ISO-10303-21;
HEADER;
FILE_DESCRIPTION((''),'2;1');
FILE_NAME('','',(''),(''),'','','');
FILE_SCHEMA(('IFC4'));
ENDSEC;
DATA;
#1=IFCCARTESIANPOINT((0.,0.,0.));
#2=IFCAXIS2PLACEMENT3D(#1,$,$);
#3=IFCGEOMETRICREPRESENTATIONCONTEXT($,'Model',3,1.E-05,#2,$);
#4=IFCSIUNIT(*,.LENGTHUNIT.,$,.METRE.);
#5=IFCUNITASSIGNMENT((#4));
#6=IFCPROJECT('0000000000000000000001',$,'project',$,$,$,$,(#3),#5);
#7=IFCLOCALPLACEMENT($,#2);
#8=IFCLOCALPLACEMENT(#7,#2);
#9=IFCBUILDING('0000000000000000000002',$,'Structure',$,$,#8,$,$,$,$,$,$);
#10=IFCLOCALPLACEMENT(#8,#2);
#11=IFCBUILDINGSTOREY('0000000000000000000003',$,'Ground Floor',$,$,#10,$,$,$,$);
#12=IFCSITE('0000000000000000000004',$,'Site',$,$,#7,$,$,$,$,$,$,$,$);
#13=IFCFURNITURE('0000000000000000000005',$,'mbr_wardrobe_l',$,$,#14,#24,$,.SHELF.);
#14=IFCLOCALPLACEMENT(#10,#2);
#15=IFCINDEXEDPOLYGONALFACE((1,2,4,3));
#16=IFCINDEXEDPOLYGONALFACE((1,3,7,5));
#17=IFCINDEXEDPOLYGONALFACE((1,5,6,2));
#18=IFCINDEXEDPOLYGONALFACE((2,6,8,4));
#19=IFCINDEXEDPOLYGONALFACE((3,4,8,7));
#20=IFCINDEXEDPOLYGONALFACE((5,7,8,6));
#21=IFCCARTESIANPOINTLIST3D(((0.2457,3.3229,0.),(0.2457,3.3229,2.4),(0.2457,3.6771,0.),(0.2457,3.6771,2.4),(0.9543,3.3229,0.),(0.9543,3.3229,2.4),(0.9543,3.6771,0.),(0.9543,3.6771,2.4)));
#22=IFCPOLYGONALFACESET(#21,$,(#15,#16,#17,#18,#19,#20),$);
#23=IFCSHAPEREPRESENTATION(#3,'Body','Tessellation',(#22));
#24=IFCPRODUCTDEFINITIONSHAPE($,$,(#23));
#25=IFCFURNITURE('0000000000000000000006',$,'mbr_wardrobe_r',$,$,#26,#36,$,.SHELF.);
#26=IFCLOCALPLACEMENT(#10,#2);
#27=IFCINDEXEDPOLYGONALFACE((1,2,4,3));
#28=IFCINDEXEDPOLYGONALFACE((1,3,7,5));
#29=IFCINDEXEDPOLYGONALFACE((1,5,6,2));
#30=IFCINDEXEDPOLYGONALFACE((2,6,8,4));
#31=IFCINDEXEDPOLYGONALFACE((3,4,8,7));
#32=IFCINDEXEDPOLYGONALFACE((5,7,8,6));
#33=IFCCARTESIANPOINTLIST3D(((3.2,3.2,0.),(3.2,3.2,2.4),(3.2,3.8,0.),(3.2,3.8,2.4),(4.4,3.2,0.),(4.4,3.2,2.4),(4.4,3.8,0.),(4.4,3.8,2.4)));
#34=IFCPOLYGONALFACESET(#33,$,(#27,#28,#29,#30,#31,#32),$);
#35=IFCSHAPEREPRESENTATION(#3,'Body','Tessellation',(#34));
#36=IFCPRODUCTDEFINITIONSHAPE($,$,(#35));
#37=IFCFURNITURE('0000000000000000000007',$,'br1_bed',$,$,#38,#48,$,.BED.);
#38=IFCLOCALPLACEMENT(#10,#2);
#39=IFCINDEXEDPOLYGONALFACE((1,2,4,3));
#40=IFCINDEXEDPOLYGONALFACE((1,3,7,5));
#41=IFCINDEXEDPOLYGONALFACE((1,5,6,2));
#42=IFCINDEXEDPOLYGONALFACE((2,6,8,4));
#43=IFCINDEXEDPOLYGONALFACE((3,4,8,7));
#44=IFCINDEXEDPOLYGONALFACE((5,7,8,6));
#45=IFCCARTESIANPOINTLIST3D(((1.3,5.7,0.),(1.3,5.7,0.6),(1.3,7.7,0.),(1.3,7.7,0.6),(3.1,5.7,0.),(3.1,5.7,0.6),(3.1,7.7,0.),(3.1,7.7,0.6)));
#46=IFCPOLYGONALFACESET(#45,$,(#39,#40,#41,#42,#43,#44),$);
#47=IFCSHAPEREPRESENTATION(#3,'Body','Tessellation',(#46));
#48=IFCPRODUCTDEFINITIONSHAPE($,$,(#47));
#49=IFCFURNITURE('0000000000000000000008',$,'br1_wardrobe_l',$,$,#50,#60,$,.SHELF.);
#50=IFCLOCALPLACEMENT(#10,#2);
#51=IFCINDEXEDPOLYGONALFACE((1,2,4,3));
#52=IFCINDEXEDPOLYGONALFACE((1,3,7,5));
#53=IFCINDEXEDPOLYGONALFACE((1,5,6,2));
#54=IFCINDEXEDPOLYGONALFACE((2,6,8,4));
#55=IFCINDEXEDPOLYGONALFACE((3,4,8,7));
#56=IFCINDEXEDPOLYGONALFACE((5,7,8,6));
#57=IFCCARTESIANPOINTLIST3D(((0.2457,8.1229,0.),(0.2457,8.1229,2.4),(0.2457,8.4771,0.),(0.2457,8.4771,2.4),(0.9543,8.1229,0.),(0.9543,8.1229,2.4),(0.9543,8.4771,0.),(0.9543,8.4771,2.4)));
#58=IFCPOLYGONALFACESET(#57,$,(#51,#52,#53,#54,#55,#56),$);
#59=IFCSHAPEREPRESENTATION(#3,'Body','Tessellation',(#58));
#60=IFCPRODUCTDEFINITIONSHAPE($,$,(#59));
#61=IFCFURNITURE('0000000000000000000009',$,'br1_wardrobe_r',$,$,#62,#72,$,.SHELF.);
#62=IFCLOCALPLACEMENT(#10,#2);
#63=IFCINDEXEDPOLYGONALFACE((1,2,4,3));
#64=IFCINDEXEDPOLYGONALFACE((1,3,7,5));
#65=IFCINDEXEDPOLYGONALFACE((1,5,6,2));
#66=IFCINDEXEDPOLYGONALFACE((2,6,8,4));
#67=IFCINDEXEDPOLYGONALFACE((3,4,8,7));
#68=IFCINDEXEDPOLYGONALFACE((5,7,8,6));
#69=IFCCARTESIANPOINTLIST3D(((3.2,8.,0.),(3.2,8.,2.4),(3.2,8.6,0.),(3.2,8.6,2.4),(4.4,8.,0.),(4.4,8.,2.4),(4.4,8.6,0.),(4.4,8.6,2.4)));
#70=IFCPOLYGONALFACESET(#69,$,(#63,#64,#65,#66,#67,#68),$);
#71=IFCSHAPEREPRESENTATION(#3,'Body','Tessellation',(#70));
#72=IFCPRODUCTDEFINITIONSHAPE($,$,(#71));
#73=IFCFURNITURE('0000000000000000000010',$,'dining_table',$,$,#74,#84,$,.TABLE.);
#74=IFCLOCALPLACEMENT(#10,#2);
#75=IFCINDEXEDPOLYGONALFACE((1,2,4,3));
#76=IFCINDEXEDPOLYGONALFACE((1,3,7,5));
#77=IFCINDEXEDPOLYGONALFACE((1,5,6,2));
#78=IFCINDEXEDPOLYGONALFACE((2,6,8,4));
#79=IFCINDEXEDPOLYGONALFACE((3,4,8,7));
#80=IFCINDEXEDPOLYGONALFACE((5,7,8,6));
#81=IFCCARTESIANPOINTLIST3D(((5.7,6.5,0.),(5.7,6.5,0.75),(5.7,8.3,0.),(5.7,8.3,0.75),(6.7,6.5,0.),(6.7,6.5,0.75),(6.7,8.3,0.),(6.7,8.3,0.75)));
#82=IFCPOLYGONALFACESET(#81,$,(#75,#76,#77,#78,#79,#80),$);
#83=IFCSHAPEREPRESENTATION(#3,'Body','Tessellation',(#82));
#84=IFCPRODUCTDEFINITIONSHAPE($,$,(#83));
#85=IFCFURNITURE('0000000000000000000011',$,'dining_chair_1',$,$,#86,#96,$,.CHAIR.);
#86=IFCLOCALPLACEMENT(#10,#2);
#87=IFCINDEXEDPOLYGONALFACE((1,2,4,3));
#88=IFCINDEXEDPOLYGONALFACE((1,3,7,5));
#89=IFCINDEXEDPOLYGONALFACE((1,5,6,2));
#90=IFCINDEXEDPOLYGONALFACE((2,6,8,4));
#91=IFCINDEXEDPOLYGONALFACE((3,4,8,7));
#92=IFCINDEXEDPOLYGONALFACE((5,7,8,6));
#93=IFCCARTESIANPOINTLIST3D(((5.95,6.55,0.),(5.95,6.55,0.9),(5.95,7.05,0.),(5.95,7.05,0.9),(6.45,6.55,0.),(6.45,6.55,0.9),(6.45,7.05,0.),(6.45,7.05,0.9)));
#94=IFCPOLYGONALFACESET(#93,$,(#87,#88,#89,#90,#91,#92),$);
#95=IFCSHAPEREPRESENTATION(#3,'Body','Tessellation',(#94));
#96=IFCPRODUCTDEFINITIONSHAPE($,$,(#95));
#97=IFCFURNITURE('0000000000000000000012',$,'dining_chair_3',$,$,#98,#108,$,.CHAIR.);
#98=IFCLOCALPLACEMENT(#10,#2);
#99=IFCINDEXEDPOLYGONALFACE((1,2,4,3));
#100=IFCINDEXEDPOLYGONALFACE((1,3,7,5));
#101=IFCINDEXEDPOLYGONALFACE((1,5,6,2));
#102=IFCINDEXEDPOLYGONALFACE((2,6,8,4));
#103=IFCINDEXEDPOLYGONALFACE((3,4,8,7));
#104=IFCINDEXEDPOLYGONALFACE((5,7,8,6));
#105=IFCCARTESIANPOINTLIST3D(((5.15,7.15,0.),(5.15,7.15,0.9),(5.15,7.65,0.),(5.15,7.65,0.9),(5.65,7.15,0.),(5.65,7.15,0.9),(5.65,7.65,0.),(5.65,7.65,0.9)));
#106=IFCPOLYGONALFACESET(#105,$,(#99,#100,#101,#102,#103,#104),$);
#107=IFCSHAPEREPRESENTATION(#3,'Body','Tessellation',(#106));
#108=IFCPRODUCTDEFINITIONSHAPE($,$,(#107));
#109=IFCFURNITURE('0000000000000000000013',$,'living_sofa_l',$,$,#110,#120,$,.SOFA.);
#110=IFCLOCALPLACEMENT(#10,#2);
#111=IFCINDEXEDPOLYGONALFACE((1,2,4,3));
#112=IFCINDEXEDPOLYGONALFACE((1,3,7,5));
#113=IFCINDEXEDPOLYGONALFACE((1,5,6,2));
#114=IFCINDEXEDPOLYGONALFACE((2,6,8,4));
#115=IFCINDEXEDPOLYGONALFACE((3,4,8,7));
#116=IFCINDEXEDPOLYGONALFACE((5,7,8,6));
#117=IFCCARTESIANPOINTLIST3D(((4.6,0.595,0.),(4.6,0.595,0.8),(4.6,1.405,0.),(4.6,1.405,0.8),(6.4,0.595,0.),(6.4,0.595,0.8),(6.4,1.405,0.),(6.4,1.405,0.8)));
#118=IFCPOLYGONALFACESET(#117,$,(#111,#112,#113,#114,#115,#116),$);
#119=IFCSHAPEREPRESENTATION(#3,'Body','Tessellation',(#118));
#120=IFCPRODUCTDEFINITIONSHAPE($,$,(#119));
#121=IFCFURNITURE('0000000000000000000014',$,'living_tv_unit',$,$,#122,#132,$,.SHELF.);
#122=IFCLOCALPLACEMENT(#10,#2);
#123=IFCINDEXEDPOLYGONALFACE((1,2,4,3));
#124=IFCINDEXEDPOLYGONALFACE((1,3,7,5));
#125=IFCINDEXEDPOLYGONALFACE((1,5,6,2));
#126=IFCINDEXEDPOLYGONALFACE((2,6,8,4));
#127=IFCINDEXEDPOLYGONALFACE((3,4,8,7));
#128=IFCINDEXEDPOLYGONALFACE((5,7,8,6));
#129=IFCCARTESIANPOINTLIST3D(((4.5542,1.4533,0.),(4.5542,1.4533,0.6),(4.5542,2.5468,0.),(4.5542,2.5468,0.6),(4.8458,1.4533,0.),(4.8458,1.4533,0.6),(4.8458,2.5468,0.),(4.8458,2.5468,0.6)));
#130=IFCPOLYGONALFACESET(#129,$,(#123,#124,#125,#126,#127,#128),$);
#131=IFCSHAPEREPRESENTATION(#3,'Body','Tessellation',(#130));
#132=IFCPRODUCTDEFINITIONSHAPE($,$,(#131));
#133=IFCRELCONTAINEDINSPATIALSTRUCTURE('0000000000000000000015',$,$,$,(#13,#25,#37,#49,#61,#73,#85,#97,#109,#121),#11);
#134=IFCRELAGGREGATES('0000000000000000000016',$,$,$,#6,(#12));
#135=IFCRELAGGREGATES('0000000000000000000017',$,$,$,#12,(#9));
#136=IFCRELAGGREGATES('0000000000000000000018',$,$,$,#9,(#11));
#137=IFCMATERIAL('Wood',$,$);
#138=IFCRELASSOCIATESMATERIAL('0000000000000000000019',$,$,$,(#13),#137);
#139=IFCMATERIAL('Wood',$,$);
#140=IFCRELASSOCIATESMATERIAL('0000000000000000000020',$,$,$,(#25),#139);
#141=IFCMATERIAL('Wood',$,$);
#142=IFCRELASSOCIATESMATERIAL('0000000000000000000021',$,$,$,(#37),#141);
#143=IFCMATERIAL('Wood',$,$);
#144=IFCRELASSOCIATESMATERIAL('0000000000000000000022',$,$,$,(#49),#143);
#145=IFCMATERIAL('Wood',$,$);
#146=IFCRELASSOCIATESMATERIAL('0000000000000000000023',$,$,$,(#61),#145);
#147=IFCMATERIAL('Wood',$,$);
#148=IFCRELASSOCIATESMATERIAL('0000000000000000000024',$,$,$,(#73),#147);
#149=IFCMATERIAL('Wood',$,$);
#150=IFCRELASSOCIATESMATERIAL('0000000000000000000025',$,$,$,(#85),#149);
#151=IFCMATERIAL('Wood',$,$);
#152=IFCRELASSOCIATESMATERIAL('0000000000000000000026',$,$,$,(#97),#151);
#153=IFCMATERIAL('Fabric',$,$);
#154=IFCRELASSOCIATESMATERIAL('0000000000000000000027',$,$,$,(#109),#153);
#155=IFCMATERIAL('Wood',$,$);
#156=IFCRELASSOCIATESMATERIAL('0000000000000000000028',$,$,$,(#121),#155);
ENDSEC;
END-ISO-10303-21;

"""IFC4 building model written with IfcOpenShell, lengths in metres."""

from ifc_helpers import new_model, si_unit, frame, origin, place, context, project, spatial, polyline, outline, extrude, material, element, save


model = new_model("IFC4")

# Units and contexts
model_context = context("Model", 3, precision=1e-05, world=origin())
ifc_project = project(units=[si_unit("LENGTHUNIT", "METRE")], contexts=[model_context])

# Site, building, storey
site_placement = place(None, origin())
site = spatial("IfcSite", under=ifc_project, at=site_placement, Name="Site")
building_placement = place(site_placement, origin())
building = spatial("IfcBuilding", under=site, at=building_placement, Name="Structure")
storey_placement = place(building_placement, origin())
storey = spatial("IfcBuildingStorey", under=building, at=storey_placement, Name="Ground Floor")

# Furniture
ifc_material_1 = material(Name="Wood")
furniture_1_placement = place(storey_placement, frame((0.6, 3.5, 0.0)))
element("IfcFurniture", 1, at=furniture_1_placement, inside=storey, material=ifc_material_1, Name="mbr_wardrobe_l", PredefinedType="SHELF", context=model_context, shape_type="SweptSolid", body=[
    extrude(outline(polyline([(-0.3543, -0.1771), (0.3543, -0.1771), (0.3543, 0.1771), (-0.3543, 0.1771), (-0.3543, -0.1771)])), origin(), (0.0, 0.0, 1.0), 2.4),
])
ifc_material_2 = material(Name="Wood")
furniture_2_placement = place(storey_placement, frame((3.8, 3.5, 0.0)))
element("IfcFurniture", 2, at=furniture_2_placement, inside=storey, material=ifc_material_2, Name="mbr_wardrobe_r", PredefinedType="SHELF", context=model_context, shape_type="SweptSolid", body=[
    extrude(outline(polyline([(-0.6, -0.3), (0.6, -0.3), (0.6, 0.3), (-0.6, 0.3), (-0.6, -0.3)])), origin(), (0.0, 0.0, 1.0), 2.4),
])
ifc_material_3 = material(Name="Wood")
furniture_3_placement = place(storey_placement, frame((2.2, 6.7, 0.0)))
element("IfcFurniture", 3, at=furniture_3_placement, inside=storey, material=ifc_material_3, Name="br1_bed", PredefinedType="BED", context=model_context, shape_type="SweptSolid", body=[
    extrude(outline(polyline([(-0.9, -1.0), (0.9, -1.0), (0.9, 1.0), (-0.9, 1.0), (-0.9, -1.0)])), origin(), (0.0, 0.0, 1.0), 0.6),
])
ifc_material_4 = material(Name="Wood")
furniture_4_placement = place(storey_placement, frame((0.6, 8.3, 0.0)))
element("IfcFurniture", 4, at=furniture_4_placement, inside=storey, material=ifc_material_4, Name="br1_wardrobe_l", PredefinedType="SHELF", context=model_context, shape_type="SweptSolid", body=[
    extrude(outline(polyline([(-0.3543, -0.1771), (0.3543, -0.1771), (0.3543, 0.1771), (-0.3543, 0.1771), (-0.3543, -0.1771)])), origin(), (0.0, 0.0, 1.0), 2.4),
])
ifc_material_5 = material(Name="Wood")
furniture_5_placement = place(storey_placement, frame((3.8, 8.3, 0.0)))
element("IfcFurniture", 5, at=furniture_5_placement, inside=storey, material=ifc_material_5, Name="br1_wardrobe_r", PredefinedType="SHELF", context=model_context, shape_type="SweptSolid", body=[
    extrude(outline(polyline([(-0.6, -0.3), (0.6, -0.3), (0.6, 0.3), (-0.6, 0.3), (-0.6, -0.3)])), origin(), (0.0, 0.0, 1.0), 2.4),
])
ifc_material_6 = material(Name="Wood")
furniture_6_placement = place(storey_placement, frame((6.2, 7.4, 0.0)))
element("IfcFurniture", 6, at=furniture_6_placement, inside=storey, material=ifc_material_6, Name="dining_table", PredefinedType="TABLE", context=model_context, shape_type="SweptSolid", body=[
    extrude(outline(polyline([(-0.5, -0.9), (0.5, -0.9), (0.5, 0.9), (-0.5, 0.9), (-0.5, -0.9)])), origin(), (0.0, 0.0, 1.0), 0.75),
])
ifc_material_7 = material(Name="Wood")
furniture_7_placement = place(storey_placement, frame((6.2, 6.8, 0.0)))
element("IfcFurniture", 7, at=furniture_7_placement, inside=storey, material=ifc_material_7, Name="dining_chair_1", PredefinedType="CHAIR", context=model_context, shape_type="SweptSolid", body=[
    extrude(outline(polyline([(-0.25, -0.25), (0.25, -0.25), (0.25, 0.25), (-0.25, 0.25), (-0.25, -0.25)])), origin(), (0.0, 0.0, 1.0), 0.9),
])
ifc_material_8 = material(Name="Wood")
furniture_8_placement = place(storey_placement, frame((5.4, 7.4, 0.0)))
element("IfcFurniture", 8, at=furniture_8_placement, inside=storey, material=ifc_material_8, Name="dining_chair_3", PredefinedType="CHAIR", context=model_context, shape_type="SweptSolid", body=[
    extrude(outline(polyline([(-0.25, -0.25), (0.25, -0.25), (0.25, 0.25), (-0.25, 0.25), (-0.25, -0.25)])), origin(), (0.0, 0.0, 1.0), 0.9),
])
ifc_material_9 = material(Name="Fabric")
furniture_9_placement = place(storey_placement, frame((5.5, 1.0, 0.0)))
element("IfcFurniture", 9, at=furniture_9_placement, inside=storey, material=ifc_material_9, Name="living_sofa_l", PredefinedType="SOFA", context=model_context, shape_type="SweptSolid", body=[
    extrude(outline(polyline([(-0.9, -0.405), (0.9, -0.405), (0.9, 0.405), (-0.9, 0.405), (-0.9, -0.405)])), origin(), (0.0, 0.0, 1.0), 0.8),
])
ifc_material_10 = material(Name="Wood")
furniture_10_placement = place(storey_placement, frame((4.7, 2.0, 0.0)))
element("IfcFurniture", 10, at=furniture_10_placement, inside=storey, material=ifc_material_10, Name="living_tv_unit", PredefinedType="SHELF", context=model_context, shape_type="SweptSolid", body=[
    extrude(outline(polyline([(-0.1458, -0.5467), (0.1458, -0.5467), (0.1458, 0.5467), (-0.1458, 0.5467), (-0.1458, -0.5467)])), origin(), (0.0, 0.0, 1.0), 0.6),
])

save(model, "model.ifc")
